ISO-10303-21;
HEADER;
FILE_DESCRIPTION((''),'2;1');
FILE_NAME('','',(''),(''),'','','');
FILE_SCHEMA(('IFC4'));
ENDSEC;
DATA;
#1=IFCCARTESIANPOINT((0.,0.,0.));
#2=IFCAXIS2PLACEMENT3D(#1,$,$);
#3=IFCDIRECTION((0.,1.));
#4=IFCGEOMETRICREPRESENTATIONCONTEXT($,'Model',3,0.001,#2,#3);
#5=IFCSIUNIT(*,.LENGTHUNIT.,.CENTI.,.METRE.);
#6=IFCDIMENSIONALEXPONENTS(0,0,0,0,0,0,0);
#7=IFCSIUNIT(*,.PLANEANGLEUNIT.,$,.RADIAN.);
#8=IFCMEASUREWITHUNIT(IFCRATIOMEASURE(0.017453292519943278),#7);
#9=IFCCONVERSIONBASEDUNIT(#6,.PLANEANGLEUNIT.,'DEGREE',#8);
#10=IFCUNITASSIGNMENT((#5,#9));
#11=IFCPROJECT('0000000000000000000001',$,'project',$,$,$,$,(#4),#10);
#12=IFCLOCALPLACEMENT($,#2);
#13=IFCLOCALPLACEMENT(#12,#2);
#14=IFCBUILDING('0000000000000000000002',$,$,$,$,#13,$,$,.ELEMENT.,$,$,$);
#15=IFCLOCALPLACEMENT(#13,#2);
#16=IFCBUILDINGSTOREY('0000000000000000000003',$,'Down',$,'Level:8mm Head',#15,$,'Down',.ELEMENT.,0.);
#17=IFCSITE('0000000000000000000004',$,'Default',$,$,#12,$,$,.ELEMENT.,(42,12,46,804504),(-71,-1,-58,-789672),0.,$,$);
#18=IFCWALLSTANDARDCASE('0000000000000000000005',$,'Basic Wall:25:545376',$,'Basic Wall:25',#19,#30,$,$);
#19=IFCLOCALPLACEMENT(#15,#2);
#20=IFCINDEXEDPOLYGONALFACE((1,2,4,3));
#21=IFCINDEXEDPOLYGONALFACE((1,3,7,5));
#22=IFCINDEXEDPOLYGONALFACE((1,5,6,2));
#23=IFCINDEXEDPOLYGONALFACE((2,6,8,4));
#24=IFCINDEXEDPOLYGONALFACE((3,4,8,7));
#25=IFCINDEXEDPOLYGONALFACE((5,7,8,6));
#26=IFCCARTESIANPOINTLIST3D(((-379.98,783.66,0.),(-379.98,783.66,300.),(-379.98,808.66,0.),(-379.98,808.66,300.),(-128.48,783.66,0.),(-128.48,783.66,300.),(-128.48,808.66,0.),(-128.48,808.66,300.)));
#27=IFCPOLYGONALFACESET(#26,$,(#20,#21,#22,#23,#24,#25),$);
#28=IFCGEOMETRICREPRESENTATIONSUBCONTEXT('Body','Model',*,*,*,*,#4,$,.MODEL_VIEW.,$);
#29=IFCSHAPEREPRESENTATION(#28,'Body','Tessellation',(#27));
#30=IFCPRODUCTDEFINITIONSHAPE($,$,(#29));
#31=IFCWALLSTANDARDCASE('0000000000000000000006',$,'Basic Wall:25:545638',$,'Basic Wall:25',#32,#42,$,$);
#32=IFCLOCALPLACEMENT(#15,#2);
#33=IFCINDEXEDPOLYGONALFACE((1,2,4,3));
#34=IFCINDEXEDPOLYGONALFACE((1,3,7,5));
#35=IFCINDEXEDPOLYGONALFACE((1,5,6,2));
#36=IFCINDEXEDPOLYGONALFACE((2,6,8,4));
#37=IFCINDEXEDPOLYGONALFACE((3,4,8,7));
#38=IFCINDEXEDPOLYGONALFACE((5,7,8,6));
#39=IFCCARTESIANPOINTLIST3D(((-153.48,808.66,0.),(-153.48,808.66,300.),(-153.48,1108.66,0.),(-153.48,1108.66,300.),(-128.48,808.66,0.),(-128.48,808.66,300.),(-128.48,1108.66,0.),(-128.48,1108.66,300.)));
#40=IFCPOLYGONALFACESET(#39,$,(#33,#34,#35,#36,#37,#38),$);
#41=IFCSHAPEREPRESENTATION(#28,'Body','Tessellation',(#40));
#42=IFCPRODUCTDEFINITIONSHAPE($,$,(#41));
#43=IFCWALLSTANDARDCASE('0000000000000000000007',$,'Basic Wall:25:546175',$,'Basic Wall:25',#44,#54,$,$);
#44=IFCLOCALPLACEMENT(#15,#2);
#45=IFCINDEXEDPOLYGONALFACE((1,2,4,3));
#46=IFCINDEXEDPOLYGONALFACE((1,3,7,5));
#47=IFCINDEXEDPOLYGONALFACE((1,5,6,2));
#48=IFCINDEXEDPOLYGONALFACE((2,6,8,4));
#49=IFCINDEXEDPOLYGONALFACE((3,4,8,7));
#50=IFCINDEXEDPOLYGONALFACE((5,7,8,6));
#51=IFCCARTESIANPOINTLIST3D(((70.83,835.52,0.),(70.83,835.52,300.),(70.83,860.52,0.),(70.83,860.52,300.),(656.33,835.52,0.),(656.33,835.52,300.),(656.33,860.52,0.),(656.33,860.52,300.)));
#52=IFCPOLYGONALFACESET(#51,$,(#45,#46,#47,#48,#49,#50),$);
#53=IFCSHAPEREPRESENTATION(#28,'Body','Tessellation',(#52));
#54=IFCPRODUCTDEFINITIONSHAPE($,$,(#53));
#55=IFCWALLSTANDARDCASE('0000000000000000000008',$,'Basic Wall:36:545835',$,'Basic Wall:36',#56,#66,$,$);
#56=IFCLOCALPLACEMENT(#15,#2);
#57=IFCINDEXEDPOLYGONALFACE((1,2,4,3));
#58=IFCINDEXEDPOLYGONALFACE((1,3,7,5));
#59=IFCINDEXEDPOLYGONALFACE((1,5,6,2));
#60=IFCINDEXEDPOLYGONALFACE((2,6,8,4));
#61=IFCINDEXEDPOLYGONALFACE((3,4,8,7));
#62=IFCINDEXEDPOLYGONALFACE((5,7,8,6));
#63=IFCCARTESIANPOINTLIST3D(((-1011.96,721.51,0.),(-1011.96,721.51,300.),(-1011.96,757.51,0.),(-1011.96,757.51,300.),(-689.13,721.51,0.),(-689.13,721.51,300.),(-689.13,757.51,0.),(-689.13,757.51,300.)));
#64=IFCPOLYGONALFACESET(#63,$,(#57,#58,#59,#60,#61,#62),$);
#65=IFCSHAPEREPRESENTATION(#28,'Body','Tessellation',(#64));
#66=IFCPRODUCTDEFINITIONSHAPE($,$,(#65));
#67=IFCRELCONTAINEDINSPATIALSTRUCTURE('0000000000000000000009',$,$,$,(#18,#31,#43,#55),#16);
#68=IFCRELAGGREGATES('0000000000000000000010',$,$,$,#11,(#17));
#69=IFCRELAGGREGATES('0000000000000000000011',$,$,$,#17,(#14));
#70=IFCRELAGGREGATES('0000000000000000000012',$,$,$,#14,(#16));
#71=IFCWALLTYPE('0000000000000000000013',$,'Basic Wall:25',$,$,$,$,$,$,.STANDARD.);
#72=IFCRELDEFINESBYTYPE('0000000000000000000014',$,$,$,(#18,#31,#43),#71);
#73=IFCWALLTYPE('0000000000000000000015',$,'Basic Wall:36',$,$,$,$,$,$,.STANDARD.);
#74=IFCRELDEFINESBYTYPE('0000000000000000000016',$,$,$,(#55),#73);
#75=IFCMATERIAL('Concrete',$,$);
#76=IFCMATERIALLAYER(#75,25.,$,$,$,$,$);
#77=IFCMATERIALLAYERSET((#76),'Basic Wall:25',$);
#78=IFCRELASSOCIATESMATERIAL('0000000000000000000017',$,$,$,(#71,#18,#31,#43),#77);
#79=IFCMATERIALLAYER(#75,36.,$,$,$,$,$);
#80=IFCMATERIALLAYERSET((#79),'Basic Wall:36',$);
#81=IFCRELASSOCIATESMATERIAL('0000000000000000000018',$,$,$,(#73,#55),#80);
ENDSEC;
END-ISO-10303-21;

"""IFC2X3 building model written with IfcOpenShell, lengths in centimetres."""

from ifc_helpers import new_model, entity, si_unit, converted_unit, direction, frame, frame_2d, origin, place, context, subcontext, project, spatial, rectangle, extrude, material, layer, layer_set, layer_usage, type_object, element, save


model = new_model("IFC2X3")

# Units and contexts
model_context = context("Model", 3, precision=0.001, world=origin(), true_north=direction((0.0, 1.0)))
body_context = subcontext(model_context, "Body", "Model", "MODEL_VIEW")
ifc_project = project(units=[si_unit("LENGTHUNIT", "METRE", prefix="CENTI"), converted_unit("PLANEANGLEUNIT", "DEGREE", entity("IfcRatioMeasure", 0.017453292519943278), si_unit("PLANEANGLEUNIT", "RADIAN"), dimensions=[0, 0, 0, 0, 0, 0, 0])], contexts=[model_context])

# Site, building, storey
site_placement = place(None, origin())
site = spatial("IfcSite", under=ifc_project, at=site_placement, Name="Default", CompositionType="ELEMENT", RefLatitude=(42, 12, 46, 804504), RefLongitude=(-71, -1, -58, -789672), RefElevation=0.0)
building_placement = place(site_placement, origin())
building = spatial("IfcBuilding", under=site, at=building_placement, CompositionType="ELEMENT")
storey_placement = place(building_placement, origin())
storey = spatial("IfcBuildingStorey", under=building, at=storey_placement, Name="Down", ObjectType="Level:8mm Head", LongName="Down", CompositionType="ELEMENT", Elevation=0.0)

# Walls
ifc_material = material(Name="Concrete")
ifc_layer_1 = layer(ifc_material, 25.0)
ifc_layer_set_1 = layer_set([ifc_layer_1], Name="Basic Wall:25")
ifc_layer_usage_1 = layer_usage(ifc_layer_set_1, "AXIS2", "NEGATIVE", 12.5)
wall_type_1 = type_object("IfcWallType", Name="Basic Wall:25", PredefinedType="STANDARD", material=ifc_layer_set_1)
wall_1_placement = place(storey_placement, frame((-379.98, 796.16, 0.0)))
element("IfcWallStandardCase", 1, at=wall_1_placement, inside=storey, type_object=wall_type_1, material=ifc_layer_usage_1, Name="Basic Wall:25:545376", ObjectType="Basic Wall:25", context=body_context, shape_type="SweptSolid", body=[
    extrude(rectangle(XDim=251.5, YDim=25.0, at=frame_2d((125.75, 0.0), x_axis=(-1.0, 0.0))), origin(), (0.0, 0.0, 1.0), 300.0),
])
ifc_layer_usage_2 = layer_usage(ifc_layer_set_1, "AXIS2", "POSITIVE", -12.5)
wall_2_placement = place(storey_placement, frame((-140.98, 808.66, 0.0), z_axis=(0.0, 0.0, 1.0), x_axis=(0.0, 1.0, 0.0)))
element("IfcWallStandardCase", 2, at=wall_2_placement, inside=storey, type_object=wall_type_1, material=ifc_layer_usage_2, Name="Basic Wall:25:545638", ObjectType="Basic Wall:25", context=body_context, shape_type="SweptSolid", body=[
    extrude(rectangle(XDim=300.0, YDim=25.0, at=frame_2d((150.0, 0.0), x_axis=(-1.0, 0.0))), origin(), (0.0, 0.0, 1.0), 300.0),
])
ifc_layer_usage_3 = layer_usage(ifc_layer_set_1, "AXIS2", "NEGATIVE", 12.5)
wall_3_placement = place(storey_placement, frame((70.83, 848.02, 0.0)))
element("IfcWallStandardCase", 3, at=wall_3_placement, inside=storey, type_object=wall_type_1, material=ifc_layer_usage_3, Name="Basic Wall:25:546175", ObjectType="Basic Wall:25", context=body_context, shape_type="SweptSolid", body=[
    extrude(rectangle(XDim=585.5, YDim=25.0, at=frame_2d((292.75, 0.0), x_axis=(-1.0, 0.0))), origin(), (0.0, 0.0, 1.0), 300.0),
])
ifc_layer_2 = layer(ifc_material, 36.0)
ifc_layer_set_2 = layer_set([ifc_layer_2], Name="Basic Wall:36")
ifc_layer_usage_4 = layer_usage(ifc_layer_set_2, "AXIS2", "POSITIVE", -18.0)
wall_type_2 = type_object("IfcWallType", Name="Basic Wall:36", PredefinedType="STANDARD", material=ifc_layer_set_2)
wall_4_placement = place(storey_placement, frame((-689.13, 739.51, 0.0), z_axis=(0.0, 0.0, 1.0), x_axis=(-1.0, 0.0, 0.0)))
element("IfcWallStandardCase", 4, at=wall_4_placement, inside=storey, type_object=wall_type_2, material=ifc_layer_usage_4, Name="Basic Wall:36:545835", ObjectType="Basic Wall:36", context=body_context, shape_type="SweptSolid", body=[
    extrude(rectangle(XDim=322.84, YDim=36.0, at=frame_2d((161.42, 0.0), x_axis=(-1.0, 0.0))), origin(), (0.0, 0.0, 1.0), 300.0),
])

save(model, "model.ifc")
